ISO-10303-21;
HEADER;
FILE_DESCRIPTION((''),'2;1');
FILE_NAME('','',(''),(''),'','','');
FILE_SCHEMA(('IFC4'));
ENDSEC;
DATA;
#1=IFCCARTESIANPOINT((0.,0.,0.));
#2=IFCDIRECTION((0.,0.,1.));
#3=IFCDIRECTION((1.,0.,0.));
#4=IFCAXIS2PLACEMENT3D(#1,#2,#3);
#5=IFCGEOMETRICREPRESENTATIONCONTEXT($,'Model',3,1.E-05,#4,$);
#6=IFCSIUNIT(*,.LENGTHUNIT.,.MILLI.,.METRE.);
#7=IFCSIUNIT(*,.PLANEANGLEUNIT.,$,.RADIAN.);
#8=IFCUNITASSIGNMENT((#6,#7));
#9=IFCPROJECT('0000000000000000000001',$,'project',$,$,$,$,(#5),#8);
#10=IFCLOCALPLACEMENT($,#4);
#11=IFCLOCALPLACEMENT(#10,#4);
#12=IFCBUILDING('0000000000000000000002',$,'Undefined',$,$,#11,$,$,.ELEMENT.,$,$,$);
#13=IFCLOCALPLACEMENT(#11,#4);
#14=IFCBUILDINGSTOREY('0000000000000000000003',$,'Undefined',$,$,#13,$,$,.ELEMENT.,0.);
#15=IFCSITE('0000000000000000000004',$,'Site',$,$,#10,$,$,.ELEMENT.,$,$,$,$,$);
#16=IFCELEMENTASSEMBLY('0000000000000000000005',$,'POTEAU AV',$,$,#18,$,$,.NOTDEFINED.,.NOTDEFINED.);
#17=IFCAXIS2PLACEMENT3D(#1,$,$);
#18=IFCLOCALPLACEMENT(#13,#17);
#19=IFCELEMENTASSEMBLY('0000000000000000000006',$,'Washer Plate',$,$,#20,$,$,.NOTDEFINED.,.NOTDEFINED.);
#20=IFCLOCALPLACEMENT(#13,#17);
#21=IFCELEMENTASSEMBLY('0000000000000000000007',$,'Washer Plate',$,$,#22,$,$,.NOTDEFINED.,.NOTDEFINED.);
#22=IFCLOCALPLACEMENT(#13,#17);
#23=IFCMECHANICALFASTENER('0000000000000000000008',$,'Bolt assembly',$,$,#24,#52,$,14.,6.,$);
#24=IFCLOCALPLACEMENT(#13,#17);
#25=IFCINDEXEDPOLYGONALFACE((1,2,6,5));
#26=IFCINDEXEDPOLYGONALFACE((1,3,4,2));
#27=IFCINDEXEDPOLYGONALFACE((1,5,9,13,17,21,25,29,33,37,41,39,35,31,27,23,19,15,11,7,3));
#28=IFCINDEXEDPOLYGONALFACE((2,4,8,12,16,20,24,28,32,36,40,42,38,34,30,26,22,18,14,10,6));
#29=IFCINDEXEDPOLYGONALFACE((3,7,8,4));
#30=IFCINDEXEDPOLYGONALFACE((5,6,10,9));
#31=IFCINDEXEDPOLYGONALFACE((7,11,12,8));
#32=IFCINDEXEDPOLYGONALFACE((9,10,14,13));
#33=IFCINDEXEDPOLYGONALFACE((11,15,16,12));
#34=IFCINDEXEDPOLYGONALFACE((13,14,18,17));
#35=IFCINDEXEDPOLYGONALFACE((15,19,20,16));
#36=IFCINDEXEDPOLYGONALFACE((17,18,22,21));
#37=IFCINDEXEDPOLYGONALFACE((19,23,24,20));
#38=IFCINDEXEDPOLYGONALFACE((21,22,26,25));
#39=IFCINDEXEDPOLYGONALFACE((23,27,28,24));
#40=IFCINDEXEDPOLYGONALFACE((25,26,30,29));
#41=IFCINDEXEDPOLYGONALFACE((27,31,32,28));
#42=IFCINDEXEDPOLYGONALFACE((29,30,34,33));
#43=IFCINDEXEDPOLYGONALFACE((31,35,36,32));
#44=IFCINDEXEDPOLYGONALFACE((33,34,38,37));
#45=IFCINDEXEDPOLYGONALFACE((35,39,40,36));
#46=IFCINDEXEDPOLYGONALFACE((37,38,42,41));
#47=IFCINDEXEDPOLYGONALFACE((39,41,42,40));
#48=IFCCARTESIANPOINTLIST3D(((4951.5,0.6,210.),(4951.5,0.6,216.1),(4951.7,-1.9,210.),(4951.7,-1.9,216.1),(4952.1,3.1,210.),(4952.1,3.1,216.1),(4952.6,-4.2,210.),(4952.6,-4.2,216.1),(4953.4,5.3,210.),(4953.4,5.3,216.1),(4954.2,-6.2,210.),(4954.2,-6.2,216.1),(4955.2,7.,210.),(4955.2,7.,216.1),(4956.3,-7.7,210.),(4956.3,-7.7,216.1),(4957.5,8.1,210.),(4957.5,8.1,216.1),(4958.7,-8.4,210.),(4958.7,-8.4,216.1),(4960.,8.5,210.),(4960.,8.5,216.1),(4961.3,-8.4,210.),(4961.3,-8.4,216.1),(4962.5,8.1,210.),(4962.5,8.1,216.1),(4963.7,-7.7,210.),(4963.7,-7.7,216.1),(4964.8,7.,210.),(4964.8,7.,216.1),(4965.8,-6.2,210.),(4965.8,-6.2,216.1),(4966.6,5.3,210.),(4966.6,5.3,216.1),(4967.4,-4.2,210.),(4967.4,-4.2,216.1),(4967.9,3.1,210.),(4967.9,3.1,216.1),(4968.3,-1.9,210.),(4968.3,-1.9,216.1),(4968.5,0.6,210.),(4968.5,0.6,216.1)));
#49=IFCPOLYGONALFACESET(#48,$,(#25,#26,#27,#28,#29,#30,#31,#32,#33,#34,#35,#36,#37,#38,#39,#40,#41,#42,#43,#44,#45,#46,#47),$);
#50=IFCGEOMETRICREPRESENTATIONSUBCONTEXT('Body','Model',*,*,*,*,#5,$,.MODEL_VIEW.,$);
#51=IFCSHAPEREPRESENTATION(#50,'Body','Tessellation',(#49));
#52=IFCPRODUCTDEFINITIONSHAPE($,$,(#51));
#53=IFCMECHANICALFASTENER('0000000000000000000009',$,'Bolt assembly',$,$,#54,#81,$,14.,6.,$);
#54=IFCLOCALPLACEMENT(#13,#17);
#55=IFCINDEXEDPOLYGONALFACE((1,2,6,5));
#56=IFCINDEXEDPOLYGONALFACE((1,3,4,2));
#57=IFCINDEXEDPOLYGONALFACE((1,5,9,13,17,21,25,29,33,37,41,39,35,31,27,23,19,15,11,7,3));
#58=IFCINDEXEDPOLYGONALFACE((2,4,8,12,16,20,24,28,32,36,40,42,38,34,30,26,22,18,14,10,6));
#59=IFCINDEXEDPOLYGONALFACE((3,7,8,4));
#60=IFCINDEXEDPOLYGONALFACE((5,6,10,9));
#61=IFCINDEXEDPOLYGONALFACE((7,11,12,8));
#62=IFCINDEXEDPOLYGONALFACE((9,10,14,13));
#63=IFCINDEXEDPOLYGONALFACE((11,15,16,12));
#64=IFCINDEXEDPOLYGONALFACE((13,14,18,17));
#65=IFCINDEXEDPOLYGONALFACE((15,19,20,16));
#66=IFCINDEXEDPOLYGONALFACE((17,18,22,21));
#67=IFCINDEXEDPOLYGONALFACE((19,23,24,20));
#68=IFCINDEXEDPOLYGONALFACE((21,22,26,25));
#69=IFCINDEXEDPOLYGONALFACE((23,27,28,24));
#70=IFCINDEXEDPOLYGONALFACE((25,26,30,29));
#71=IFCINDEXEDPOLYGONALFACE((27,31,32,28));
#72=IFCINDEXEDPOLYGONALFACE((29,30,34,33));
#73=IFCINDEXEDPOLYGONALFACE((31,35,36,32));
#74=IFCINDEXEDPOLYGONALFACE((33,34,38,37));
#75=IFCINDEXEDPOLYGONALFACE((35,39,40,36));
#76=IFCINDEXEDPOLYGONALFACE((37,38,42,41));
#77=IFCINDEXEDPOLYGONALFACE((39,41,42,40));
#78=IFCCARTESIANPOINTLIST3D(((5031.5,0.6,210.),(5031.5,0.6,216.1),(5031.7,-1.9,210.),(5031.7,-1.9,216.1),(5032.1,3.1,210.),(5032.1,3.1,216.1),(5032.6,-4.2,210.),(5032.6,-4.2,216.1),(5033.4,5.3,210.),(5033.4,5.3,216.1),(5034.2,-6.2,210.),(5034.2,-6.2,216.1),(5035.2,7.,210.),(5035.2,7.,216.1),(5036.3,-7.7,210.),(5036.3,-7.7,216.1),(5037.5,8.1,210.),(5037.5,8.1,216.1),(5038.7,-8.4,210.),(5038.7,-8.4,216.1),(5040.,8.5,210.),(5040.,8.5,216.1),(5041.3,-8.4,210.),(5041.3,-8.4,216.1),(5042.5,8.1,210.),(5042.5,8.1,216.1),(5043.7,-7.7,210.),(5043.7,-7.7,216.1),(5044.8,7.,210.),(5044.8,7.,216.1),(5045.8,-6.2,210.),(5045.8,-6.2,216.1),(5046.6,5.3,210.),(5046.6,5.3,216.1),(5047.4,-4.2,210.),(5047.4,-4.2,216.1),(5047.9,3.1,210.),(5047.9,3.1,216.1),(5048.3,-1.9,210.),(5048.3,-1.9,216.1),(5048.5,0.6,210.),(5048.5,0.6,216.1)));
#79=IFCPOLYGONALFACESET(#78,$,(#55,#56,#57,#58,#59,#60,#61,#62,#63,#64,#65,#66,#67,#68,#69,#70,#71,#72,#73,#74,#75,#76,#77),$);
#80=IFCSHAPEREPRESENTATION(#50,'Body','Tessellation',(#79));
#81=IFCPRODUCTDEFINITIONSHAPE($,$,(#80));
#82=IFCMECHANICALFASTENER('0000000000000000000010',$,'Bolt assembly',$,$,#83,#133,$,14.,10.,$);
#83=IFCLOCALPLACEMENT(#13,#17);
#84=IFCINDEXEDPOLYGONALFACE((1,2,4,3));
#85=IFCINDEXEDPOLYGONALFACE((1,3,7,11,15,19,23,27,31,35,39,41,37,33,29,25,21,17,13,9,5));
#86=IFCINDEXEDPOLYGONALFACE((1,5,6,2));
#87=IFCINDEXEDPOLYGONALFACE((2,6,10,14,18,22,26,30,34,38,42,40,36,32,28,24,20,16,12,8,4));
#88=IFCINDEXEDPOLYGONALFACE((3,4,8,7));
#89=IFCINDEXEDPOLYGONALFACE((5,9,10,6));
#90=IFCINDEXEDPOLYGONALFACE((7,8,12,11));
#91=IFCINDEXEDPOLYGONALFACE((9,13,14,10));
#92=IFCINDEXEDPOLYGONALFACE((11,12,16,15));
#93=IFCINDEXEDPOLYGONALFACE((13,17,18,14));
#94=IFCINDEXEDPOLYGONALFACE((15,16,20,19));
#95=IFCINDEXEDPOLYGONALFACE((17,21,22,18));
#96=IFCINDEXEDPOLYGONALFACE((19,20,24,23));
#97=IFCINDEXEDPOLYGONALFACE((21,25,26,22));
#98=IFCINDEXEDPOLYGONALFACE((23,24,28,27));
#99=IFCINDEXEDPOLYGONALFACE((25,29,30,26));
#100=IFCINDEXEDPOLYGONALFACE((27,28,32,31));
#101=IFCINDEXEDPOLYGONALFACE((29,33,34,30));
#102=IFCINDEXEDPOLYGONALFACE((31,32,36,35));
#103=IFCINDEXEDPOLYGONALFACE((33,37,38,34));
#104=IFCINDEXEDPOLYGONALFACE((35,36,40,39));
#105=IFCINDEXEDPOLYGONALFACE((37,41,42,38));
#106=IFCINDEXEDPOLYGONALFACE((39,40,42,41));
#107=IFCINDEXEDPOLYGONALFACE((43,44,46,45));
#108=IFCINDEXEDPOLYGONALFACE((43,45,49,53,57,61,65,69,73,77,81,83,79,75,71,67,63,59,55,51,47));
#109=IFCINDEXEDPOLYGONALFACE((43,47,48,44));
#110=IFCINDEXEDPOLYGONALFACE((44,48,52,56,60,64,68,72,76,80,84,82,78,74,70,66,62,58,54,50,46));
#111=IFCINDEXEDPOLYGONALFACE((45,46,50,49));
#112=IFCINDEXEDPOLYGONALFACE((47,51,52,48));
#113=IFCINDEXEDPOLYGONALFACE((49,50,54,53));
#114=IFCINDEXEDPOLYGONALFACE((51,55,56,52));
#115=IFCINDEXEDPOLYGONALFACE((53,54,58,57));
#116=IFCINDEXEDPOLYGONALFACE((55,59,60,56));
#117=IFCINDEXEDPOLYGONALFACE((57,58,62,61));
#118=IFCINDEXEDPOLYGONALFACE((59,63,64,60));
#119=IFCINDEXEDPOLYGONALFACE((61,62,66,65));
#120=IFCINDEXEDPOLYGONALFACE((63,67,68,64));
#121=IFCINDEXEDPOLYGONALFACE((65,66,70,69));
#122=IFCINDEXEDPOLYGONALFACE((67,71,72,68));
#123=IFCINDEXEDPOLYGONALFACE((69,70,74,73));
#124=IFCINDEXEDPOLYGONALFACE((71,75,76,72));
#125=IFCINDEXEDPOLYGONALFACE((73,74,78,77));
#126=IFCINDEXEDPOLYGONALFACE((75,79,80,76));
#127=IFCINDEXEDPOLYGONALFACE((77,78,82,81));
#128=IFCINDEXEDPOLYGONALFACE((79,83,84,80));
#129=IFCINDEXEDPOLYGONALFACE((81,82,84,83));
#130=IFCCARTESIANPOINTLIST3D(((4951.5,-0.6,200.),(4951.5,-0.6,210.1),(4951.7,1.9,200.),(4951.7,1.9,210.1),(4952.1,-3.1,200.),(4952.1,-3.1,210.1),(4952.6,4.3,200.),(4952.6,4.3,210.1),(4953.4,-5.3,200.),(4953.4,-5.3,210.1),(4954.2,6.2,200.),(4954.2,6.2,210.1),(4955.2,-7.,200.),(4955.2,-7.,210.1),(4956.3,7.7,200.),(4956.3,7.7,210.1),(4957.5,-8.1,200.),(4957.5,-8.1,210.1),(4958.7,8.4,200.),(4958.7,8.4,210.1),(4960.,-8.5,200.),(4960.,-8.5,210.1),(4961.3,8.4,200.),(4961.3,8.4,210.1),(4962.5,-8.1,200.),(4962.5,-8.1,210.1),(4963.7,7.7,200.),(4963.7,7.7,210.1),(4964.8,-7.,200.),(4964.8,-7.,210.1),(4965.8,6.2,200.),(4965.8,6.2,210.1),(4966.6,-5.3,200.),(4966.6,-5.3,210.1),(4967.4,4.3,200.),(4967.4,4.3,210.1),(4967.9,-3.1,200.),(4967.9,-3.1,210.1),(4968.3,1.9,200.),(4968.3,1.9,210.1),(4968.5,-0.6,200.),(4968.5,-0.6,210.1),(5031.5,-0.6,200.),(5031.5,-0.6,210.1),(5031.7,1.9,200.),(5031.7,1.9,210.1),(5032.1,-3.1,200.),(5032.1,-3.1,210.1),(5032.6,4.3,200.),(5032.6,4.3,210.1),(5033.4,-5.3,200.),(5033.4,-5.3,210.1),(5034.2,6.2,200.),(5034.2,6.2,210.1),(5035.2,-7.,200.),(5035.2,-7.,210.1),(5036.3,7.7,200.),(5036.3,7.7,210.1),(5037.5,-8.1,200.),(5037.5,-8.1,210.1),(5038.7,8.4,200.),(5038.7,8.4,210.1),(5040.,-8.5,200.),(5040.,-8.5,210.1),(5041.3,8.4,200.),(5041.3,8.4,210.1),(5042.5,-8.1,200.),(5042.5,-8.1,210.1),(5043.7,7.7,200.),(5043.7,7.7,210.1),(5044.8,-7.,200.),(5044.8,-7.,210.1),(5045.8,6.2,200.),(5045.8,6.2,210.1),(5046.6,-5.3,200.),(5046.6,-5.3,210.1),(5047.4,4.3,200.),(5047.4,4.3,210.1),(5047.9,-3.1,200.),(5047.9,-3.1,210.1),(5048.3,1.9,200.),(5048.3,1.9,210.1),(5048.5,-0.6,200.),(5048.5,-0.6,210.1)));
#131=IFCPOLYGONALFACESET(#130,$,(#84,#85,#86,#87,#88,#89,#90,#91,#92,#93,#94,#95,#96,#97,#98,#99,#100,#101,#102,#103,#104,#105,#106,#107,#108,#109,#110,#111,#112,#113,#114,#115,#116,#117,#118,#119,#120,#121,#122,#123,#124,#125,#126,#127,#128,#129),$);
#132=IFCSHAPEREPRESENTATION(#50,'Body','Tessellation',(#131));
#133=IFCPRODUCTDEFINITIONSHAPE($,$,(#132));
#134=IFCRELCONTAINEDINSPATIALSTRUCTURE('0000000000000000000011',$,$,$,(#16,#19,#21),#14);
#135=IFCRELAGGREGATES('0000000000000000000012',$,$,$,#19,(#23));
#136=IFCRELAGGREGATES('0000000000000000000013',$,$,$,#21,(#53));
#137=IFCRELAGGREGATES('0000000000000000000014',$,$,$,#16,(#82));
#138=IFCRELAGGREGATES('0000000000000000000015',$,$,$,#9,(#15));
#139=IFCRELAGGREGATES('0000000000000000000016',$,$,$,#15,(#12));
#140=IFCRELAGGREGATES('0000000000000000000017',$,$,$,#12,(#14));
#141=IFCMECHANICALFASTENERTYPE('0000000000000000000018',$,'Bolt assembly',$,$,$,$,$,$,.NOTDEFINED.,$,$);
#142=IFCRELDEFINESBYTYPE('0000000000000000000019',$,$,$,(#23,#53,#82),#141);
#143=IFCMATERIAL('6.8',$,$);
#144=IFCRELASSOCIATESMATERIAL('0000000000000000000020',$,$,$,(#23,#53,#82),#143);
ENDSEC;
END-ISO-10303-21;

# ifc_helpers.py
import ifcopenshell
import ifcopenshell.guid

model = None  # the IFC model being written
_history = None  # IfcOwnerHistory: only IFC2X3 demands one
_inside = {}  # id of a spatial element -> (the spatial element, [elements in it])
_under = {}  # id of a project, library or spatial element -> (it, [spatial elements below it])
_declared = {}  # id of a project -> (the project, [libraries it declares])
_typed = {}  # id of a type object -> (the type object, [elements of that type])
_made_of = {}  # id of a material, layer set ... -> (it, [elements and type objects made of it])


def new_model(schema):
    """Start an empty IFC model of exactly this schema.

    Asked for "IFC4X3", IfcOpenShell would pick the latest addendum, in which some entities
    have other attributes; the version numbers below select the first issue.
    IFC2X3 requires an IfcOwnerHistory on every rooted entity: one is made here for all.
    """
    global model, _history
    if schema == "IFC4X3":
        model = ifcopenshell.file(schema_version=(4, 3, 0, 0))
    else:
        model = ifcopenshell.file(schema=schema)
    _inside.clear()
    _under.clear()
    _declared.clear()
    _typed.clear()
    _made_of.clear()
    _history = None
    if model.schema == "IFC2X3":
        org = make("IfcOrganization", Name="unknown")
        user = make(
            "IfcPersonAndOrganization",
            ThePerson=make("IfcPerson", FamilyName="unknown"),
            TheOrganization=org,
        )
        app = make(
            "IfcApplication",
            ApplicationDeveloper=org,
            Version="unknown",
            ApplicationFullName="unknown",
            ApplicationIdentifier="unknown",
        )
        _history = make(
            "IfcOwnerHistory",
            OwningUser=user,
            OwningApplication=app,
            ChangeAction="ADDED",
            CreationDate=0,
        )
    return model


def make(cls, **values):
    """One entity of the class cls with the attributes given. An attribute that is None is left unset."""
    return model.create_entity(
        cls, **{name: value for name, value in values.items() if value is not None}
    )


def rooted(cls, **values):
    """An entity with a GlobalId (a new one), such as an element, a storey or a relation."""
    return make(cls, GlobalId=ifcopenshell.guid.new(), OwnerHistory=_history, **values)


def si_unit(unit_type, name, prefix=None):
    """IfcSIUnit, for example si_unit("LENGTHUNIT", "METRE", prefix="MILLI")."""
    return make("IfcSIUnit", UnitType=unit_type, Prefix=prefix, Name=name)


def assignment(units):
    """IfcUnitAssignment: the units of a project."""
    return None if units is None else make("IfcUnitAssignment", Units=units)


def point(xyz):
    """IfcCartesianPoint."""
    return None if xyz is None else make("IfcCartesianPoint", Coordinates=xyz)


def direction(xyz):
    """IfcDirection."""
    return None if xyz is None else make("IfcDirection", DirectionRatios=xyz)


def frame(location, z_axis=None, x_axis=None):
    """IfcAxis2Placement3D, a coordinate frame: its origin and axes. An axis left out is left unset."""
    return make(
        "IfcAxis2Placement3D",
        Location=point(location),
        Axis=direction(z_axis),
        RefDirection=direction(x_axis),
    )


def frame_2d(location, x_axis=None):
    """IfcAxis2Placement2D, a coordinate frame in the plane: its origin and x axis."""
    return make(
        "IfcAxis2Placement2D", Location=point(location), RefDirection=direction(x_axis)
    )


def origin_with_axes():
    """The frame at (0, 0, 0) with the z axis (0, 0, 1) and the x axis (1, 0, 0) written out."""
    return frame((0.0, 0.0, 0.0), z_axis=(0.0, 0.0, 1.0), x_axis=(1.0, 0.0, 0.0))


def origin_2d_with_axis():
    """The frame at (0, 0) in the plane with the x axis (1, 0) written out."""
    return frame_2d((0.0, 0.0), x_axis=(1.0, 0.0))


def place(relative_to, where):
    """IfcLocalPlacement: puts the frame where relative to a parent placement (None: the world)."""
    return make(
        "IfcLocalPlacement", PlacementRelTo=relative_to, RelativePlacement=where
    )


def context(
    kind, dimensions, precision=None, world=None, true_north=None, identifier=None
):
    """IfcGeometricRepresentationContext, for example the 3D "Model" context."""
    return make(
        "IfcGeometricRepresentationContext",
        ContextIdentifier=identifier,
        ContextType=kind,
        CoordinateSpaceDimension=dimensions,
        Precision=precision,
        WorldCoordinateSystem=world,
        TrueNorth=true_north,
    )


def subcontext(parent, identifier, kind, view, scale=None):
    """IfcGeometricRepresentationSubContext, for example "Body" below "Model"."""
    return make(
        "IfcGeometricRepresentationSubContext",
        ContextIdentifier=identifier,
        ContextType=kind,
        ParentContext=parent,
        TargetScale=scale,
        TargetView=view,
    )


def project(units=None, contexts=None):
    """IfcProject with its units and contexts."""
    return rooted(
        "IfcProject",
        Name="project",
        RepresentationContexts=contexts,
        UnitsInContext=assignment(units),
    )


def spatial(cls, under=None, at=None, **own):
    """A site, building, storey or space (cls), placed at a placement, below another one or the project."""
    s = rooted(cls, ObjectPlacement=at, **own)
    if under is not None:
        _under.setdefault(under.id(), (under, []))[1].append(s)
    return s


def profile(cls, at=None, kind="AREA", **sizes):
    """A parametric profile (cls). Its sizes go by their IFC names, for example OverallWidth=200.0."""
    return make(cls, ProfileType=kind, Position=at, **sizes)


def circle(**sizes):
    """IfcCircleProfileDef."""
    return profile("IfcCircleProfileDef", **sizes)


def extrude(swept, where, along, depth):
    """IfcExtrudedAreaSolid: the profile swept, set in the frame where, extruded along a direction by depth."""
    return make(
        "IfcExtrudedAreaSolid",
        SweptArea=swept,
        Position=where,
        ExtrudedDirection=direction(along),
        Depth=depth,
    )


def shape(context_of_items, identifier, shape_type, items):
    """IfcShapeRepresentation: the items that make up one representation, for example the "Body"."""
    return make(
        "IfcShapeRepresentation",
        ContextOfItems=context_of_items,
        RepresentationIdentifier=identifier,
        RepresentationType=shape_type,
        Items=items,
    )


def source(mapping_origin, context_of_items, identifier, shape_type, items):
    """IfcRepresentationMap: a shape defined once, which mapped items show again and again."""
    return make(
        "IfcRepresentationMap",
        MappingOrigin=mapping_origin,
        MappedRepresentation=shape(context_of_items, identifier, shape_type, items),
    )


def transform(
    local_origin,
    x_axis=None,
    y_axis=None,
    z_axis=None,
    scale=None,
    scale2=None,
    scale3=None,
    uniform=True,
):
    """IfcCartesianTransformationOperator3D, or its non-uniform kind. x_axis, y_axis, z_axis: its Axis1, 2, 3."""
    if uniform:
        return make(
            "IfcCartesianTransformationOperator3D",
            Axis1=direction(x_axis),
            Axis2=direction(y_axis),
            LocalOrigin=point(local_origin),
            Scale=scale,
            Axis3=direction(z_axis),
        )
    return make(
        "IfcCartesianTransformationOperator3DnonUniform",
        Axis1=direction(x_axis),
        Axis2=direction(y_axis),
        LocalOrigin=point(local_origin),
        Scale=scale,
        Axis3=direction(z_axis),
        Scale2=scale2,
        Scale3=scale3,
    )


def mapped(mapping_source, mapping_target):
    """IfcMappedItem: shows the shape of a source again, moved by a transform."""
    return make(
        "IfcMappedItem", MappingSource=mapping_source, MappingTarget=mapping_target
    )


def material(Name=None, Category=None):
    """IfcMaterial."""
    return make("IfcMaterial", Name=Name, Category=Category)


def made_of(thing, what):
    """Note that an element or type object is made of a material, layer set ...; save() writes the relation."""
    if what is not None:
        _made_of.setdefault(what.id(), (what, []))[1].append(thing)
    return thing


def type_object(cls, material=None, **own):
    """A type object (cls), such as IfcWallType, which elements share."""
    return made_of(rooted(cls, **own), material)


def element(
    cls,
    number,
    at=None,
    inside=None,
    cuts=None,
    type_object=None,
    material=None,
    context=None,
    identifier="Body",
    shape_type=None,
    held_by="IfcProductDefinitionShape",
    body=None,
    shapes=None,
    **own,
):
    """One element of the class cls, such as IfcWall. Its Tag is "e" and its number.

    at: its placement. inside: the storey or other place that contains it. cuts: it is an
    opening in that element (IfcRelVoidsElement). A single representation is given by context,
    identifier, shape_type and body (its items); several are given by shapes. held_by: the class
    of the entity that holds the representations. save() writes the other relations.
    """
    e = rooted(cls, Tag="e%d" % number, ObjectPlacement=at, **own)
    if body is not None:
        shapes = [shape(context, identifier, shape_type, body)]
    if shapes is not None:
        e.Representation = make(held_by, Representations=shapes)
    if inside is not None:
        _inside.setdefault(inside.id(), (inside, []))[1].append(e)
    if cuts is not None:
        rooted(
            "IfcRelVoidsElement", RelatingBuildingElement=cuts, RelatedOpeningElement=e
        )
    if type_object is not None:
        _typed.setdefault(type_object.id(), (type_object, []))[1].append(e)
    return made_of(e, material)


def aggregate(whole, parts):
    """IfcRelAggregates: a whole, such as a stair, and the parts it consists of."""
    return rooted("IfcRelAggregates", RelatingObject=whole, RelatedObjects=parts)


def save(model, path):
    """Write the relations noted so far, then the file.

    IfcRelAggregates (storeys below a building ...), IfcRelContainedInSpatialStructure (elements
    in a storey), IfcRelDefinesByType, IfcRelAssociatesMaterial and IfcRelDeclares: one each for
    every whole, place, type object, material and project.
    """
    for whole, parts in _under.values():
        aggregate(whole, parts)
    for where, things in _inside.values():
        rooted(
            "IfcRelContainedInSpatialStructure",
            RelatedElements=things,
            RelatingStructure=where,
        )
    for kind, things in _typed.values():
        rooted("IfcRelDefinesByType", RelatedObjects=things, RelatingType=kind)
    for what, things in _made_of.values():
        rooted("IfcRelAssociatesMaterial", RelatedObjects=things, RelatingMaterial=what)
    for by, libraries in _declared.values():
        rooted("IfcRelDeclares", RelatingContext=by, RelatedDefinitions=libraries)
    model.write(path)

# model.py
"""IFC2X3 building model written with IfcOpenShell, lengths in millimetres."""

from ifc_helpers import new_model, si_unit, frame, origin_with_axes, origin_2d_with_axis, place, context, subcontext, project, spatial, circle, extrude, source, transform, mapped, material, type_object, element, aggregate, save


model = new_model("IFC2X3")

# Units and contexts
model_context = context("Model", 3, precision=1e-05, world=origin_with_axes())
body_context = subcontext(model_context, "Body", "Model", "MODEL_VIEW")
ifc_project = project(units=[si_unit("LENGTHUNIT", "METRE", prefix="MILLI"), si_unit("PLANEANGLEUNIT", "RADIAN")], contexts=[model_context])

# Site, building, storey
site_placement = place(None, origin_with_axes())
site = spatial("IfcSite", under=ifc_project, at=site_placement, Name="Site", CompositionType="ELEMENT")
building_placement = place(site_placement, origin_with_axes())
building = spatial("IfcBuilding", under=site, at=building_placement, Name="Undefined", CompositionType="ELEMENT")
storey_placement = place(building_placement, origin_with_axes())
storey = spatial("IfcBuildingStorey", under=building, at=storey_placement, Name="Undefined", CompositionType="ELEMENT", Elevation=0.0)

# Element assembly
assembly_1_placement = place(storey_placement, origin_with_axes())
assembly_1 = element("IfcElementAssembly", 1, at=assembly_1_placement, inside=storey, Name="POTEAU AV", AssemblyPlace="NOTDEFINED", PredefinedType="NOTDEFINED")

# Element assemblies
assembly_2_placement = place(storey_placement, origin_with_axes())
assembly_2 = element("IfcElementAssembly", 2, at=assembly_2_placement, inside=storey, Name="Washer Plate", AssemblyPlace="NOTDEFINED", PredefinedType="NOTDEFINED")
assembly_3_placement = place(storey_placement, origin_with_axes())
assembly_3 = element("IfcElementAssembly", 3, at=assembly_3_placement, inside=storey, Name="Washer Plate", AssemblyPlace="NOTDEFINED", PredefinedType="NOTDEFINED")

# Mechanical fasteners
mechanical_fastener_type = type_object("IfcMechanicalFastenerType", Name="Bolt assembly")
ifc_material_1 = material(Name="6.8")
shared_shape_1 = source(origin_with_axes(), body_context, "Body", "SweptSolid", [
    extrude(circle(Radius=8.5, at=origin_2d_with_axis()), frame((0.0, 0.0, 0.0), z_axis=(0.0, 1.0, 0.0), x_axis=(1.0, 0.0, 0.0)), (0.0, 0.0, 1.0), 6.1),
])
mechanical_fastener_1_placement = place(assembly_2_placement, frame((4960.0, 0.0, 210.0), z_axis=(1.0, 0.0, 0.0), x_axis=(0.0, 1.0, 0.0)))
mechanical_fastener_1 = element("IfcMechanicalFastener", 4, at=mechanical_fastener_1_placement, type_object=mechanical_fastener_type, material=ifc_material_1, Name="Bolt assembly", NominalDiameter=14.0, NominalLength=6.0, context=body_context, shape_type="MappedRepresentation", body=[
    mapped(shared_shape_1, transform((0.0, 0.0, 0.0))),
])
aggregate(assembly_2, [mechanical_fastener_1])
mechanical_fastener_2_placement = place(assembly_3_placement, frame((5040.0, 0.0, 210.0), z_axis=(1.0, 0.0, 0.0), x_axis=(0.0, 1.0, 0.0)))
mechanical_fastener_2 = element("IfcMechanicalFastener", 5, at=mechanical_fastener_2_placement, type_object=mechanical_fastener_type, material=ifc_material_1, Name="Bolt assembly", NominalDiameter=14.0, NominalLength=6.0, context=body_context, shape_type="MappedRepresentation", body=[
    mapped(shared_shape_1, transform((0.0, 0.0, 0.0))),
])
aggregate(assembly_3, [mechanical_fastener_2])
shared_shape_2 = source(origin_with_axes(), body_context, "Body", "SweptSolid", [
    extrude(circle(Radius=8.5, at=origin_2d_with_axis()), frame((0.0, -10.0, 0.0), z_axis=(0.0, 1.0, 0.0), x_axis=(1.0, 0.0, 0.0)), (0.0, 0.0, 1.0), 10.1),
])
mechanical_fastener_3_placement = place(assembly_1_placement, frame((5000.0, 48.0, 210.0), z_axis=(-1.0, 0.0, 0.0), x_axis=(0.0, -1.0, 0.0)))
mechanical_fastener_3 = element("IfcMechanicalFastener", 6, at=mechanical_fastener_3_placement, type_object=mechanical_fastener_type, material=ifc_material_1, Name="Bolt assembly", NominalDiameter=14.0, NominalLength=10.0, context=body_context, shape_type="MappedRepresentation", body=[
    mapped(shared_shape_2, transform((48.0, 0.0, -40.0))),
    mapped(shared_shape_2, transform((48.0, 0.0, 40.0))),
])
aggregate(assembly_1, [mechanical_fastener_3])

save(model, "model.ifc")
